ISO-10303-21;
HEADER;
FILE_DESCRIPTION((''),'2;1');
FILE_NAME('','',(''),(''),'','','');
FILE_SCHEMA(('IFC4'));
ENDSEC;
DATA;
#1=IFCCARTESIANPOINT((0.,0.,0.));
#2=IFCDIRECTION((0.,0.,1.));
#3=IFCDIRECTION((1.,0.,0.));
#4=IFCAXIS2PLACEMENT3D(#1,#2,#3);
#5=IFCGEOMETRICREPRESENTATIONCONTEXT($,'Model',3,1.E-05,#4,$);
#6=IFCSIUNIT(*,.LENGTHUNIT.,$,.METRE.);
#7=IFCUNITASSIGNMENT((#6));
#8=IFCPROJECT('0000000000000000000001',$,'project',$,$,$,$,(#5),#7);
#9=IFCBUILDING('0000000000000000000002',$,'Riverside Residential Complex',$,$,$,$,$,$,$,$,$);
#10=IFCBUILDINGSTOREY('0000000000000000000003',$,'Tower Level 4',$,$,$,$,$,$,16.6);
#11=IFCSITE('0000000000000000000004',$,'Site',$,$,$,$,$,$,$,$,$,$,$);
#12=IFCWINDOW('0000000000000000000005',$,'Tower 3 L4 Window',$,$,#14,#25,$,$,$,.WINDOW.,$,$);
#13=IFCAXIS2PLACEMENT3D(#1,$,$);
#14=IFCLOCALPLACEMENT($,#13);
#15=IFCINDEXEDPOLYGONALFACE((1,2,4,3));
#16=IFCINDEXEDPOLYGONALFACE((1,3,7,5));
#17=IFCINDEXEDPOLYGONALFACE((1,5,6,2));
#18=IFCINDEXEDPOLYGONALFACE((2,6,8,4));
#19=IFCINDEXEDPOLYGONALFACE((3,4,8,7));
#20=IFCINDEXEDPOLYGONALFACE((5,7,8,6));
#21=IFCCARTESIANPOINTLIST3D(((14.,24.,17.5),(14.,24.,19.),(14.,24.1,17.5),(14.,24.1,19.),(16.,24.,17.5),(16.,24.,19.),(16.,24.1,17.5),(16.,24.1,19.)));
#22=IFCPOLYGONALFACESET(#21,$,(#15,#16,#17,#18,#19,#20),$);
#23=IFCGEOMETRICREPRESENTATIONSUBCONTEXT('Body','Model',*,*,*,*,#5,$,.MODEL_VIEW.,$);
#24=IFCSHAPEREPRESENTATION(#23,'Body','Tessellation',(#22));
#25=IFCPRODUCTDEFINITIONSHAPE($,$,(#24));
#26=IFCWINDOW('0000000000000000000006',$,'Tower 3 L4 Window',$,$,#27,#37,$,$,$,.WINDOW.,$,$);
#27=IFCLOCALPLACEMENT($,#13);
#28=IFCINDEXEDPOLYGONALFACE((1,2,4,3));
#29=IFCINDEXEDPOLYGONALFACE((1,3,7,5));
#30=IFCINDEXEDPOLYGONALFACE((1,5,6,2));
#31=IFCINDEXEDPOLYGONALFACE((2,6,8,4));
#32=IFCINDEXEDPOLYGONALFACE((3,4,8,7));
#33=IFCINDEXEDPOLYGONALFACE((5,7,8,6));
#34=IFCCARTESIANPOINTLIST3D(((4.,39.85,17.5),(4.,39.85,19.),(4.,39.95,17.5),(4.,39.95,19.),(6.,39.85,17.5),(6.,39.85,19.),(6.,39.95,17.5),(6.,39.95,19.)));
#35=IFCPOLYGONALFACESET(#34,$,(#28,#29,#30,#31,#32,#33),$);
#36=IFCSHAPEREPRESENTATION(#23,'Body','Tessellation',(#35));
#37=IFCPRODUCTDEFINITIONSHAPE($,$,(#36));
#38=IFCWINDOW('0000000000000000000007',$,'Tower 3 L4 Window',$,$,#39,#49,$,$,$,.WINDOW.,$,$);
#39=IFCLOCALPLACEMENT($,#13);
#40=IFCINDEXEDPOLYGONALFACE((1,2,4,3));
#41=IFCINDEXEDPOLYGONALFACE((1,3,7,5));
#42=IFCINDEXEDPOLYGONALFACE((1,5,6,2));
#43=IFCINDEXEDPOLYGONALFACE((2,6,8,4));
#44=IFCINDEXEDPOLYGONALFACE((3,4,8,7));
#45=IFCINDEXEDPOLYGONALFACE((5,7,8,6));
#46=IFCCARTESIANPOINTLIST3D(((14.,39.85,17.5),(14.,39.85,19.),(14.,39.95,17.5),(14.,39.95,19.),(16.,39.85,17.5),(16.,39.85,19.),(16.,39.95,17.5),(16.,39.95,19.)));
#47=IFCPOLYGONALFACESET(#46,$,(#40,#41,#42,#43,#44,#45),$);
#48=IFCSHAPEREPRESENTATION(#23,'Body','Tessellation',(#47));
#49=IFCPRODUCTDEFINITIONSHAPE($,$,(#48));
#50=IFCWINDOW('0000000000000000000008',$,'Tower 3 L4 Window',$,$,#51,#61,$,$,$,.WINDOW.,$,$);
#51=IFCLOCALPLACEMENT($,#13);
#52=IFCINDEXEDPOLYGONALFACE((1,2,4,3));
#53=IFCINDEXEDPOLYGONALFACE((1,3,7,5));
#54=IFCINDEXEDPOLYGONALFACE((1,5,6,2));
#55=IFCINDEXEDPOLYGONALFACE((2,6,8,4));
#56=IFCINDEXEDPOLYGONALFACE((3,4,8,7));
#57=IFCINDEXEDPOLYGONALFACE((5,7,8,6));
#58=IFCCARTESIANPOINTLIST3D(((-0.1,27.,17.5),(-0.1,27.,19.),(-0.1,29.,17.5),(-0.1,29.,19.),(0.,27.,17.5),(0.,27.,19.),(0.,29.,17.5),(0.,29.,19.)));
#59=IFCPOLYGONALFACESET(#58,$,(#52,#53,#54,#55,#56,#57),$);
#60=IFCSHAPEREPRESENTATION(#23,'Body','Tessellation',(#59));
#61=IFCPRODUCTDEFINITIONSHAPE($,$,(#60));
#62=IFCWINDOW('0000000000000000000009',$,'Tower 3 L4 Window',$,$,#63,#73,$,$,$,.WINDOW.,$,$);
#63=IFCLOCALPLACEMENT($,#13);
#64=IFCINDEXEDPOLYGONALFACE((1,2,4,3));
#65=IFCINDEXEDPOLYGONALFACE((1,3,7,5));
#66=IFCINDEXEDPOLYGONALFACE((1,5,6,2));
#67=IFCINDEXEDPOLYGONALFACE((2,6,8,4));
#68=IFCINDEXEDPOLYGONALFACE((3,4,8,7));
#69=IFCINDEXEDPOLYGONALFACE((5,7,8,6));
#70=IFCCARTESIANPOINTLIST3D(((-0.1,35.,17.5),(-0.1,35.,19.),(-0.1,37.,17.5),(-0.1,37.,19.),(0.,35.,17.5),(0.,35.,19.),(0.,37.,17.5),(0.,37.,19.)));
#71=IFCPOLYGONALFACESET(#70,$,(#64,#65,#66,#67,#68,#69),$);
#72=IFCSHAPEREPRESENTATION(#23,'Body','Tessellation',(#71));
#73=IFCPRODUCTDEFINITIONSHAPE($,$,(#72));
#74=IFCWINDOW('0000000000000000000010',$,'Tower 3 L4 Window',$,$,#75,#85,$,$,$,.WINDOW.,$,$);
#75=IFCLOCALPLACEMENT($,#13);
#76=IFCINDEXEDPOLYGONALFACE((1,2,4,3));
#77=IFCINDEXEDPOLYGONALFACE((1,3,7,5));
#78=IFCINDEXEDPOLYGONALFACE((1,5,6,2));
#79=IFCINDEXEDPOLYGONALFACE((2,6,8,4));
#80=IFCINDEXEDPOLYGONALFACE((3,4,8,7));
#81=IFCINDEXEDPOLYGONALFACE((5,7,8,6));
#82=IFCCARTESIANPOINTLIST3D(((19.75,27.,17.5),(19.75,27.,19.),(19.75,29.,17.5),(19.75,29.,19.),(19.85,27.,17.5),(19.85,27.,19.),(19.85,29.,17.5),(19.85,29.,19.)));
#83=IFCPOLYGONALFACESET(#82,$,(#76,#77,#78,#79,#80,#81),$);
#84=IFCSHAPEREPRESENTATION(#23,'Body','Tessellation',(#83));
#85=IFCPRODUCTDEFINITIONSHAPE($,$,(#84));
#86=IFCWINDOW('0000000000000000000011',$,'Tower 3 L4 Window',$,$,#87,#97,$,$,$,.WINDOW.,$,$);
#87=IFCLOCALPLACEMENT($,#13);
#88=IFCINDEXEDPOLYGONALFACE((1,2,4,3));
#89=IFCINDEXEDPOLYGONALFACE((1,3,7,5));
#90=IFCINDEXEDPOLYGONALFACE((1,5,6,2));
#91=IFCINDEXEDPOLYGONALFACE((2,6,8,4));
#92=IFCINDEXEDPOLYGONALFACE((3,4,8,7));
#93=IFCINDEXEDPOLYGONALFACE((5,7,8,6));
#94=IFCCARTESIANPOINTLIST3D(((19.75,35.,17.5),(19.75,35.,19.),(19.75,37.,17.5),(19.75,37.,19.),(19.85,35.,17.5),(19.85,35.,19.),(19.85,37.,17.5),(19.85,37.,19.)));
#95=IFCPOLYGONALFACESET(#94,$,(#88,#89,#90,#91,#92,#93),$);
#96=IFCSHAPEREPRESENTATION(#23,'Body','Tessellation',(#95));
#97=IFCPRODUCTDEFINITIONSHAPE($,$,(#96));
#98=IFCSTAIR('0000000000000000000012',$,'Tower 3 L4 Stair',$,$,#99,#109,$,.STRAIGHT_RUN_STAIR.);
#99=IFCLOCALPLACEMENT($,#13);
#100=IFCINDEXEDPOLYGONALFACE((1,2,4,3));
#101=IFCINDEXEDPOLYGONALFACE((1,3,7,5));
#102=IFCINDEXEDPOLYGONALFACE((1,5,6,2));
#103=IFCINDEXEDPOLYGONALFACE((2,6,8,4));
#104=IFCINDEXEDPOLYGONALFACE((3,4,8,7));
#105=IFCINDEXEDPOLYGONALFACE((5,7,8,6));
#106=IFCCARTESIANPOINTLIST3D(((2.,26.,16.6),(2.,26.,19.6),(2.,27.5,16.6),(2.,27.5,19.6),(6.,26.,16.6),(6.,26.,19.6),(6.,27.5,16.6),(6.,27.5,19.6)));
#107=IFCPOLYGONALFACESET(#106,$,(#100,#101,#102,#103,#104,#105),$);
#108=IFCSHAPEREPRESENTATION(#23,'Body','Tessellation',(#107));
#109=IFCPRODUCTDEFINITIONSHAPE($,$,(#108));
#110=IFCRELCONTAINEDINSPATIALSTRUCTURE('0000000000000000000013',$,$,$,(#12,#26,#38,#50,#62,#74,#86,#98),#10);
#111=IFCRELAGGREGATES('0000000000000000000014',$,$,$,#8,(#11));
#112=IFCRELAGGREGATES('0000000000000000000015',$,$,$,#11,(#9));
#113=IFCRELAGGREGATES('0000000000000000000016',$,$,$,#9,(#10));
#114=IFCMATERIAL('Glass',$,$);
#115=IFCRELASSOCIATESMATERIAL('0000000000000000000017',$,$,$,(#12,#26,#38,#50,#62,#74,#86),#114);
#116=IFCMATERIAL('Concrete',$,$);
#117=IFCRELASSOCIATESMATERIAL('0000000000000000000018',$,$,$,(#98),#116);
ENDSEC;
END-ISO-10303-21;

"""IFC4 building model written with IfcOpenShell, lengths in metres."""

from ifc_helpers import new_model, si_unit, frame, origin_with_axes, place, context, subcontext, project, spatial, line, indexed_curve, outline, extrude, material, element, save


model = new_model("IFC4")

# Units and contexts
model_context = context("Model", 3, precision=1e-05, world=origin_with_axes())
body_context = subcontext(model_context, "Body", "Model", "MODEL_VIEW")
ifc_project = project(units=[si_unit("LENGTHUNIT", "METRE")], contexts=[model_context])

# Site, building, storey
site = spatial("IfcSite", under=ifc_project, Name="Site")
building = spatial("IfcBuilding", under=site, Name="Riverside Residential Complex")
storey = spatial("IfcBuildingStorey", under=building, Name="Tower Level 4", Elevation=16.6)

# Shared definitions
ifc_material_1 = material(Name="Concrete")

# Windows
ifc_material_2 = material(Name="Glass")
for number, where, z_axis, x_axis, name in (
    (1, (14.0, 24.0, 17.5), (0.0, 0.0, 1.0), (1.0, 0.0, 0.0), "Tower 3 L4 Window"),
    (2, (4.0, 39.85, 17.5), (0.0, 0.0, 1.0), (1.0, 0.0, 0.0), "Tower 3 L4 Window"),
    (3, (14.0, 39.85, 17.5), (0.0, 0.0, 1.0), (1.0, 0.0, 0.0), "Tower 3 L4 Window"),
    (4, (0.0, 27.0, 17.5), (0.0, 0.0, 1.0), (0.0, 1.0, 0.0), "Tower 3 L4 Window"),
    (5, (0.0, 35.0, 17.5), (0.0, 0.0, 1.0), (0.0, 1.0, 0.0), "Tower 3 L4 Window"),
    (6, (19.85, 27.0, 17.5), (0.0, 0.0, 1.0), (0.0, 1.0, 0.0), "Tower 3 L4 Window"),
    (7, (19.85, 35.0, 17.5), (0.0, 0.0, 1.0), (0.0, 1.0, 0.0), "Tower 3 L4 Window"),
):
    element("IfcWindow", number, at=place(None, frame(where, z_axis=z_axis, x_axis=x_axis)), inside=storey, material=ifc_material_2, Name=name, PredefinedType="WINDOW", context=body_context, shape_type="SweptSolid", body=[
        extrude(outline(indexed_curve([(0.0, 0.0), (2.0, 0.0), (2.0, 0.1), (0.0, 0.1)], segments=[line(1, 2, 3, 4, 1)])), origin_with_axes(), (0.0, 0.0, 1.0), 1.5),
    ])

# Stair
stair_placement = place(None, frame((2.0, 26.0, 16.6), z_axis=(0.0, 0.0, 1.0), x_axis=(1.0, 0.0, 0.0)))
element("IfcStair", 8, at=stair_placement, inside=storey, material=ifc_material_1, Name="Tower 3 L4 Stair", PredefinedType="STRAIGHT_RUN_STAIR", context=body_context, shape_type="SweptSolid", body=[
    extrude(outline(indexed_curve([(0.0, 0.0), (4.0, 0.0), (4.0, 1.5), (0.0, 1.5)], segments=[line(1, 2, 3, 4, 1)])), origin_with_axes(), (0.0, 0.0, 1.0), 3.0),
])

save(model, "model.ifc")
